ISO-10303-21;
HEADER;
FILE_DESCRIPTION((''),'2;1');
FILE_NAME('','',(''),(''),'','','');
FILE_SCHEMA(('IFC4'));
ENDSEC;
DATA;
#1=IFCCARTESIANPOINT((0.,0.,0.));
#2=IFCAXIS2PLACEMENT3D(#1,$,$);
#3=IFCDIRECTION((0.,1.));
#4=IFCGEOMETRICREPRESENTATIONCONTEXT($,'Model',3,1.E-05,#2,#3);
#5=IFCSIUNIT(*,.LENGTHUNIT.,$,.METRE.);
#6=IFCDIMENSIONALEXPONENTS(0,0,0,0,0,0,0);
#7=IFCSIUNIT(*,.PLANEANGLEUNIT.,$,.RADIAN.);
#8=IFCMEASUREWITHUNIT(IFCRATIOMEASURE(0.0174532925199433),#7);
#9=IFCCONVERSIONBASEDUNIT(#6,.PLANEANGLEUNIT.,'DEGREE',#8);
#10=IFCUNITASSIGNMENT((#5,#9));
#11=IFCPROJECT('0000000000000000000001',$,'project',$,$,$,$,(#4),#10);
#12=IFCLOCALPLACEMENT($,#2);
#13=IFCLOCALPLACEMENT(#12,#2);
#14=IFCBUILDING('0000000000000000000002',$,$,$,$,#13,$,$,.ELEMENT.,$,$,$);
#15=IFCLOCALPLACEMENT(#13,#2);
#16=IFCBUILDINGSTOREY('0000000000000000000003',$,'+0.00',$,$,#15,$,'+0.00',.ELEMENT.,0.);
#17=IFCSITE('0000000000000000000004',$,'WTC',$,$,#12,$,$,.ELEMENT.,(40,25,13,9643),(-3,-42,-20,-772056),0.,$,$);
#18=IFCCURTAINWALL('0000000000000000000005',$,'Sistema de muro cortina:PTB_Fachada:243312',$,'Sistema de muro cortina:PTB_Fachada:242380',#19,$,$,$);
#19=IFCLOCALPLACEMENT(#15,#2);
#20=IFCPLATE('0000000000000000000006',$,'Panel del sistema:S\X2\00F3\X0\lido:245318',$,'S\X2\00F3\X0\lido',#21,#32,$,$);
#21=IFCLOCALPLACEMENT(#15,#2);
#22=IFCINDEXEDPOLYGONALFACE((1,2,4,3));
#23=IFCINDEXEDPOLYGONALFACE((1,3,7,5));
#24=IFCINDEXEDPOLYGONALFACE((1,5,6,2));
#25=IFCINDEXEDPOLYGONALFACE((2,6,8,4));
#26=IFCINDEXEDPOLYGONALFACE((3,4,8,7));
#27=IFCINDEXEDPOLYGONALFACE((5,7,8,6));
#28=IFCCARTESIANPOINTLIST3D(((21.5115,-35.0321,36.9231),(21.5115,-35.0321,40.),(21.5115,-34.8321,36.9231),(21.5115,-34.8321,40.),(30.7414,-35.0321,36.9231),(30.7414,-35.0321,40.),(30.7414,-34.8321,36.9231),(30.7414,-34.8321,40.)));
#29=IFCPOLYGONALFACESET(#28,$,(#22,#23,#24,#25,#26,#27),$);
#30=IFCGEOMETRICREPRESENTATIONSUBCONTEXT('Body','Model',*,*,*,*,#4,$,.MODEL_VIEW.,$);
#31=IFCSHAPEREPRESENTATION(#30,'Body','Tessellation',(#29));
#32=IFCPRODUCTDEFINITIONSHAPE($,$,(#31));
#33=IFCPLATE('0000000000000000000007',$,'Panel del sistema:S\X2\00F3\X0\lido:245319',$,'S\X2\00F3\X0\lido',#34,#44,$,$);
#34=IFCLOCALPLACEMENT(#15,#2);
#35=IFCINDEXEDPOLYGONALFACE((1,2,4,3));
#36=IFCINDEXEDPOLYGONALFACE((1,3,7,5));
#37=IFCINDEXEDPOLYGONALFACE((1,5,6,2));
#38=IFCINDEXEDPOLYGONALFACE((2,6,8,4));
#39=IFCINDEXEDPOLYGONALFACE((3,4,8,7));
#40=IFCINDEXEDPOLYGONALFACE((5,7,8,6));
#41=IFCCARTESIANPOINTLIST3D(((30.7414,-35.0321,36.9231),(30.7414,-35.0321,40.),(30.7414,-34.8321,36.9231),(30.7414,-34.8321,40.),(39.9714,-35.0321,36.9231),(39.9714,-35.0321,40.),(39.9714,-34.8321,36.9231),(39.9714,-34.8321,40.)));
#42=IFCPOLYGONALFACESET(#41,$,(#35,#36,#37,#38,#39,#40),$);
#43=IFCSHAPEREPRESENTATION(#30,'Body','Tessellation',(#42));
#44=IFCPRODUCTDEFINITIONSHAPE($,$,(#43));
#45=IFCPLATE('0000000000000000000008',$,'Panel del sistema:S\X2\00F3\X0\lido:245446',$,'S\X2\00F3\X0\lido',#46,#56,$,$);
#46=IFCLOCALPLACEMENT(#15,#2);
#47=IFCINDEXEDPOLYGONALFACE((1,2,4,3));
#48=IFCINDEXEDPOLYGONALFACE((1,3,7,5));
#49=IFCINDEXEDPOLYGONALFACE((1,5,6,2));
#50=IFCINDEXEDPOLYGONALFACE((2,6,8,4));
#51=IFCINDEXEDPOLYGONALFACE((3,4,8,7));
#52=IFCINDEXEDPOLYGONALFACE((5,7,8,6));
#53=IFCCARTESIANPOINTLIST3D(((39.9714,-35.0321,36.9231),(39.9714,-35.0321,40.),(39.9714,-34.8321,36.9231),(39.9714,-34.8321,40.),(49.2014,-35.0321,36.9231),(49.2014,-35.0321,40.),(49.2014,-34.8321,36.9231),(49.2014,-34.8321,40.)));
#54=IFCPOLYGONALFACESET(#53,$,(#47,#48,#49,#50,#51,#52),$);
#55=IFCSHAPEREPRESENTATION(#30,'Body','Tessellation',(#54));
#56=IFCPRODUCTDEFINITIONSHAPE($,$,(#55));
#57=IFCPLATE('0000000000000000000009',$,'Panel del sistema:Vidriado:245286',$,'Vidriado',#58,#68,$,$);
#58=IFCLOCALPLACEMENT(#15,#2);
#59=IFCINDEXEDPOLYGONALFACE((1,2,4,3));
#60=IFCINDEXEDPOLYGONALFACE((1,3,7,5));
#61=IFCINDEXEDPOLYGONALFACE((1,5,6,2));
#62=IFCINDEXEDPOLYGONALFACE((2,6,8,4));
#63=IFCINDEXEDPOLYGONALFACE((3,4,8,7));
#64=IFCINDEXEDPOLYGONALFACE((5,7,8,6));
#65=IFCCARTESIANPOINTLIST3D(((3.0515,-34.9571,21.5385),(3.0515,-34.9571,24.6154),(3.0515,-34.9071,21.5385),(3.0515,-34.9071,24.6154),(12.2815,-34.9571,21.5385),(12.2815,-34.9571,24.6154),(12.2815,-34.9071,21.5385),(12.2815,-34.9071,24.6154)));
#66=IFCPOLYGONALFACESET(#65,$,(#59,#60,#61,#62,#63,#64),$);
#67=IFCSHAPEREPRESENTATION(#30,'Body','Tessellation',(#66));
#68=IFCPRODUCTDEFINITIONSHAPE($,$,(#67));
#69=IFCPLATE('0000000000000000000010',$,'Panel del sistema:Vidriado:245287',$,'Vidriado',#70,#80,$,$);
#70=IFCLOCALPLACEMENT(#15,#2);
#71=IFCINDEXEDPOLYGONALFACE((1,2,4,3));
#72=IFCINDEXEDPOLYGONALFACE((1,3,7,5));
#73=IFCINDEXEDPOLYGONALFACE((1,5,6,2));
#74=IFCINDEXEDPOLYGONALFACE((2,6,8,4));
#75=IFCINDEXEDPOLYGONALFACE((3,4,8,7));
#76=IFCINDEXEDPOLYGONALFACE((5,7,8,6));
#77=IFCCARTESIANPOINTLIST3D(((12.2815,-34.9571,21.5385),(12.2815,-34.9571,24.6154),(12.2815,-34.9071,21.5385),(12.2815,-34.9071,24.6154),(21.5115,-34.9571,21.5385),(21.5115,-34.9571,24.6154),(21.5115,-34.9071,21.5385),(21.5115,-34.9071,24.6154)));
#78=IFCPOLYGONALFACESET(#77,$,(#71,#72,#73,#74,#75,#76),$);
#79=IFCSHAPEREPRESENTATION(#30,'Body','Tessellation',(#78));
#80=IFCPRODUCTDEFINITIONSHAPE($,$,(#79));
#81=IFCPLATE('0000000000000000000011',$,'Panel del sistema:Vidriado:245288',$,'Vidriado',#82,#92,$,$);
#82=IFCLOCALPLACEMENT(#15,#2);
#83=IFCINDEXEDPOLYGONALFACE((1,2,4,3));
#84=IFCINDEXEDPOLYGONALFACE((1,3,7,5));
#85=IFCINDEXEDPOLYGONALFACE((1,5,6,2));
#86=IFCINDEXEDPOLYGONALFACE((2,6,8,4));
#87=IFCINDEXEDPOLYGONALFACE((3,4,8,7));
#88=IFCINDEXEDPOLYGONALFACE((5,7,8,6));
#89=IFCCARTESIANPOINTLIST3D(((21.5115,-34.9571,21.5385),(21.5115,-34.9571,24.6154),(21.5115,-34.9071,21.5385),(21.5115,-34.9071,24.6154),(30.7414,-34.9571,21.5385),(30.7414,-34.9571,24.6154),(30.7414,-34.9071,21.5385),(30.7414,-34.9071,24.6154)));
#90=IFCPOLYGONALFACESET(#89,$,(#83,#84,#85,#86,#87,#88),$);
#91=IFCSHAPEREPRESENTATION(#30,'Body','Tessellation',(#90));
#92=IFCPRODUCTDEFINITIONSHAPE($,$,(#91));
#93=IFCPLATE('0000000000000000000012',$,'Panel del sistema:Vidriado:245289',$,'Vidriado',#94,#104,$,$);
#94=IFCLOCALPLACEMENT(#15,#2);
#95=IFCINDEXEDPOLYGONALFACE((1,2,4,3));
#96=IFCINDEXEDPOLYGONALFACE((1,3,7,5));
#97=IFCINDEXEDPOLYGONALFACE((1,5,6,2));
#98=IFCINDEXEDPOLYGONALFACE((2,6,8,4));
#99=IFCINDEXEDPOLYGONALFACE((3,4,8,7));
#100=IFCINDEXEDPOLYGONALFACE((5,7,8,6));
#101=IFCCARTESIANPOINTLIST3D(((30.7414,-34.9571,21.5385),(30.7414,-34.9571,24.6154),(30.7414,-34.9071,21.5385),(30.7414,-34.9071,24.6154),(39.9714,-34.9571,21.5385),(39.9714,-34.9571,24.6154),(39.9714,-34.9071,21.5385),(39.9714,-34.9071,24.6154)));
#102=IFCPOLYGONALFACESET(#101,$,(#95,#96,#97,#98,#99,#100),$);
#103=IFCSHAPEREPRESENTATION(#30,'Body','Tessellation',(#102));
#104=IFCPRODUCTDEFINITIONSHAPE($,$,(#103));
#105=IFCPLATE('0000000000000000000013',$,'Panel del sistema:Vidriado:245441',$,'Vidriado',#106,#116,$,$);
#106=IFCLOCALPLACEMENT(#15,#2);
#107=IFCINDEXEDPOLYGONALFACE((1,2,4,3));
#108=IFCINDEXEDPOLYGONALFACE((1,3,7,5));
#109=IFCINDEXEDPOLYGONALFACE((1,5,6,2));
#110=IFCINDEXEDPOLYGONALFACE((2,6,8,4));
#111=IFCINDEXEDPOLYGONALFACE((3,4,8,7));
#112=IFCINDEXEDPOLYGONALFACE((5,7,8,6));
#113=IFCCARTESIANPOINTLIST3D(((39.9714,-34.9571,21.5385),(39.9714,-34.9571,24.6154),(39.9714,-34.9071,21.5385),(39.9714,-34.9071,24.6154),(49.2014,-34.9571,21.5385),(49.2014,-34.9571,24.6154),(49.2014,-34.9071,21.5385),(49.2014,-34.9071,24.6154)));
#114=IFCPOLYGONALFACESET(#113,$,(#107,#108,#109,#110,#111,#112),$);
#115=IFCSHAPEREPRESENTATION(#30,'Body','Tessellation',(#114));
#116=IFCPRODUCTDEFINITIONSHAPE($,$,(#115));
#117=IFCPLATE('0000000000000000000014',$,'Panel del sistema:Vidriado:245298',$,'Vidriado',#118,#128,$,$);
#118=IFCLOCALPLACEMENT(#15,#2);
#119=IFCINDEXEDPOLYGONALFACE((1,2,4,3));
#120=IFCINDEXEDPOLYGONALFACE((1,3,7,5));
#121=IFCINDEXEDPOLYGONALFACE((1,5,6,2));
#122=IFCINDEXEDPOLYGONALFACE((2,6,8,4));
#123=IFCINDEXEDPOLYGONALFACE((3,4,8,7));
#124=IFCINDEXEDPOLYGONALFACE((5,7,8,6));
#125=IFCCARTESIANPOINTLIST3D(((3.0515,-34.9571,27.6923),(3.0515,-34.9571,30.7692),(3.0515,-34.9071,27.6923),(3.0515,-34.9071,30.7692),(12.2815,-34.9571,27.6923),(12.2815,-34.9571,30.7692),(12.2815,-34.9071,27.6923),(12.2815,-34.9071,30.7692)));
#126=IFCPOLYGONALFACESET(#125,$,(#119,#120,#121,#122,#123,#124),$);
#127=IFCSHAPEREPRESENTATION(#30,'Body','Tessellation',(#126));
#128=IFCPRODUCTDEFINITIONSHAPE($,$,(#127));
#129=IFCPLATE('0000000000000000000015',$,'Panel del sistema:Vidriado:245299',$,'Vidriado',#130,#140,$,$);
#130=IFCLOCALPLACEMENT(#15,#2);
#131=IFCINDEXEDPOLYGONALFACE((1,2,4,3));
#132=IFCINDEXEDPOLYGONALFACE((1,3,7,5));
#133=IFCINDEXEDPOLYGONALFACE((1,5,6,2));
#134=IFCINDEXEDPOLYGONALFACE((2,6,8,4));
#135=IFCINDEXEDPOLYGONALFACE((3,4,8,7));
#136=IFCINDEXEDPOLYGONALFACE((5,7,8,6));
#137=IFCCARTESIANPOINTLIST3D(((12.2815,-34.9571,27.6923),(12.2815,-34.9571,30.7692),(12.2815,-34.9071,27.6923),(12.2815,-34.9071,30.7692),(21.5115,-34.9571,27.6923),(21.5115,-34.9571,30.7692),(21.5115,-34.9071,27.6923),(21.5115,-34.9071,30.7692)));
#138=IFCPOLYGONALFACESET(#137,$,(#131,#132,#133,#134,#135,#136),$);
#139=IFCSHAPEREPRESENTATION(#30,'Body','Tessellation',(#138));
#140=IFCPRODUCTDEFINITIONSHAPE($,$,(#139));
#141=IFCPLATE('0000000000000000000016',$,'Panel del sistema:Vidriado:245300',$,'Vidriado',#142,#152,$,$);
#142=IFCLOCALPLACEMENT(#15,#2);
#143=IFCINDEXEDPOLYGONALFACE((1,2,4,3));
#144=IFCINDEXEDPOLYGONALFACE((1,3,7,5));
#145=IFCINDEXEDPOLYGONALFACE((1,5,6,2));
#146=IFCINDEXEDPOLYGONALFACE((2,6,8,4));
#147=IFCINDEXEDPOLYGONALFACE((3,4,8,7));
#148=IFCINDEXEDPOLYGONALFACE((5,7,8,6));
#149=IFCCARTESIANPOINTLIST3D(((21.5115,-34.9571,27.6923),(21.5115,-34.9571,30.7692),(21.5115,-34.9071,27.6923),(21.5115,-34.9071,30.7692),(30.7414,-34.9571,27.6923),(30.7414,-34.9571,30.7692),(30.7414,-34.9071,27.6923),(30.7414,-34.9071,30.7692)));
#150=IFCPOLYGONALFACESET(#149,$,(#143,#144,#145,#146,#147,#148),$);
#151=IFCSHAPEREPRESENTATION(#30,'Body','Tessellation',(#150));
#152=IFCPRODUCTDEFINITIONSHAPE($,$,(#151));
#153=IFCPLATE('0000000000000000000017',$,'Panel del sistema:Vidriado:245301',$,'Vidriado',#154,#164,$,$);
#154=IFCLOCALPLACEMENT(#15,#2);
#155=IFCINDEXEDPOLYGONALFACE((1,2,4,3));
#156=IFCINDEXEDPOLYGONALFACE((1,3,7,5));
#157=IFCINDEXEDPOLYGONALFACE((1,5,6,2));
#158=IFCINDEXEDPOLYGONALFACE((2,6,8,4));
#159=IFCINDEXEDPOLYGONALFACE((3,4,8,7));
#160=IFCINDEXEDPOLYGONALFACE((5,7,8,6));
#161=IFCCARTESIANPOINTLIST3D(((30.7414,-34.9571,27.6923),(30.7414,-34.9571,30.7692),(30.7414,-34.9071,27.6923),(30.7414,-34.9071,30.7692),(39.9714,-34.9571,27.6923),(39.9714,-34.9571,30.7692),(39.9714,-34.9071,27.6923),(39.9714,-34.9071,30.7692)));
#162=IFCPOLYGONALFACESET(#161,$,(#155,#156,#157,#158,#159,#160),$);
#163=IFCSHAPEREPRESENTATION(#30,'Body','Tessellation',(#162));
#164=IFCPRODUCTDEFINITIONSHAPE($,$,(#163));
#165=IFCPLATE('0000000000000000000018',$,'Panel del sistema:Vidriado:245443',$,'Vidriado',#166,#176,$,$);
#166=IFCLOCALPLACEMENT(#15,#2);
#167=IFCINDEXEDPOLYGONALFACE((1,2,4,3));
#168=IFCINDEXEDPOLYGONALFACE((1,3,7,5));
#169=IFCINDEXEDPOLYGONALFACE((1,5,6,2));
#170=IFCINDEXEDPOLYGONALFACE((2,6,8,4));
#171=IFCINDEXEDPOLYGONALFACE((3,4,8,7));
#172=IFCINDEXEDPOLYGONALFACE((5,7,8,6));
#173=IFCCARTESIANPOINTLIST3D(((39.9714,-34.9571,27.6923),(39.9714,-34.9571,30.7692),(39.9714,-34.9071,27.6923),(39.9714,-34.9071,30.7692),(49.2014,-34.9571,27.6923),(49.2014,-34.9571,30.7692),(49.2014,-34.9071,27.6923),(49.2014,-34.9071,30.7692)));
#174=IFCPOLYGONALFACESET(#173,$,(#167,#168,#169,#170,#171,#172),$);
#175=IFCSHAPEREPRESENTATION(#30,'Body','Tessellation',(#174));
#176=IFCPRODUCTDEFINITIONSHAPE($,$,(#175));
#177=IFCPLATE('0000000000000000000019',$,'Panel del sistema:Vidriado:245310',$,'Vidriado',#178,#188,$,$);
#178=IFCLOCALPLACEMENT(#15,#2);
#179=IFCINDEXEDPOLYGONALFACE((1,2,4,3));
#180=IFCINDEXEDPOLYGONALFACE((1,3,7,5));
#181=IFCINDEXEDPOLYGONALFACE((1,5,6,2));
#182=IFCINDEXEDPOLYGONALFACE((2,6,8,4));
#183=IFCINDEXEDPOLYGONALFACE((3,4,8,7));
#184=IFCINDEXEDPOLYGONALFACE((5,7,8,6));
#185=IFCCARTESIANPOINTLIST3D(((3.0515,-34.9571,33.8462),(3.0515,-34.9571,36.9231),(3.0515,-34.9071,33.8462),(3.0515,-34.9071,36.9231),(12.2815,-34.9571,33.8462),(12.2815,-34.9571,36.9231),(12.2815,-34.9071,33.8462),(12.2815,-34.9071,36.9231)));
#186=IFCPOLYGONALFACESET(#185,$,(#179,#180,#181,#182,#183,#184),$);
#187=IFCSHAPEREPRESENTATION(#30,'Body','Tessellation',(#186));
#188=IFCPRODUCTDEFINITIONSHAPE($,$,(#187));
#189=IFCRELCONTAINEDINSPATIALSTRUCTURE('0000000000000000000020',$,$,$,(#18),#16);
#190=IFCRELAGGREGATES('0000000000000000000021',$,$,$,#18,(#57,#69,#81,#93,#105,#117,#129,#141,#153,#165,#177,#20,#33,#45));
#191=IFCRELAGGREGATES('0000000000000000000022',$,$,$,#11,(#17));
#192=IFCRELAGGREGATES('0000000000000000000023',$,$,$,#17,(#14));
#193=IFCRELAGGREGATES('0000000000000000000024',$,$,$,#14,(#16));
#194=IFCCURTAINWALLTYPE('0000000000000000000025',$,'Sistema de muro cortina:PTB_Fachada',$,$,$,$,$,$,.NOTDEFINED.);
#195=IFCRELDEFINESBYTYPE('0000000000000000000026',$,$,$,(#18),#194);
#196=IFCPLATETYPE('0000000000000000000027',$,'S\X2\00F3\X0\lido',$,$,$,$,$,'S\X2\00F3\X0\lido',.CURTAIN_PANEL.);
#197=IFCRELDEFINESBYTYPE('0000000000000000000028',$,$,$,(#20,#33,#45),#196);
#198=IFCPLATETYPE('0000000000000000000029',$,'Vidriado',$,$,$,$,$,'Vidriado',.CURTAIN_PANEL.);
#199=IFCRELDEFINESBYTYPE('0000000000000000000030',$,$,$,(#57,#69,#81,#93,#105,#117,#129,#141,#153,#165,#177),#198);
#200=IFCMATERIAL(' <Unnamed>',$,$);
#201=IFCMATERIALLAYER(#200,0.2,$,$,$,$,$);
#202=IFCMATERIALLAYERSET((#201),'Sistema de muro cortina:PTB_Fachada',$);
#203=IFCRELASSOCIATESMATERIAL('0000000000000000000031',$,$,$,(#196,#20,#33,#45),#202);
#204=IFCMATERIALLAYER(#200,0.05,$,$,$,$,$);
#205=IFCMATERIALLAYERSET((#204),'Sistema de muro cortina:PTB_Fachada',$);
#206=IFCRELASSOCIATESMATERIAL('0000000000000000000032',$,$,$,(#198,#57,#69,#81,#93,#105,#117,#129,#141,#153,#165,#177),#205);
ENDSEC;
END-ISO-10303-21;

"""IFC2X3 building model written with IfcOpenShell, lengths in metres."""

from ifc_helpers import new_model, entity, si_unit, converted_unit, direction, frame, frame_2d, origin, origin_2d_with_axis, place, context, subcontext, project, spatial, rectangle, extrude, source, transform, mapped, material, layer, layer_set, layer_usage, type_object, type_shapes, element, aggregate, save


model = new_model("IFC2X3")

# Units and contexts
model_context = context("Model", 3, precision=1e-05, world=origin(), true_north=direction((0.0, 1.0)))
body_context = subcontext(model_context, "Body", "Model", "MODEL_VIEW")
ifc_project = project(units=[si_unit("LENGTHUNIT", "METRE"), converted_unit("PLANEANGLEUNIT", "DEGREE", entity("IfcRatioMeasure", 0.0174532925199433), si_unit("PLANEANGLEUNIT", "RADIAN"), dimensions=[0, 0, 0, 0, 0, 0, 0])], contexts=[model_context])

# Site, building, storey
site_placement = place(None, origin())
site = spatial("IfcSite", under=ifc_project, at=site_placement, Name="WTC", CompositionType="ELEMENT", RefLatitude=(40, 25, 13, 9643), RefLongitude=(-3, -42, -20, -772056), RefElevation=0.0)
building_placement = place(site_placement, origin())
building = spatial("IfcBuilding", under=site, at=building_placement, CompositionType="ELEMENT")
storey_placement = place(building_placement, origin())
storey = spatial("IfcBuildingStorey", under=building, at=storey_placement, Name="+0.00", LongName="+0.00", CompositionType="ELEMENT", Elevation=0.0)

# Curtain wall, plates
curtain_wall_type = type_object("IfcCurtainWallType", Name="Sistema de muro cortina:PTB_Fachada", PredefinedType="NOTDEFINED")
curtain_wall_placement = place(storey_placement, origin())
curtain_wall = element("IfcCurtainWall", 1, at=curtain_wall_placement, inside=storey, type_object=curtain_wall_type, Name="Sistema de muro cortina:PTB_Fachada:243312", ObjectType="Sistema de muro cortina:PTB_Fachada:242380")
ifc_material_1 = material(Name=" <Unnamed>")
ifc_layer_1 = layer(ifc_material_1, 0.2)
ifc_layer_set_1 = layer_set([ifc_layer_1], Name="Sistema de muro cortina:PTB_Fachada")
plate_type_1 = type_object("IfcPlateType", Name="Sólido", ElementType="Sólido", PredefinedType="CURTAIN_PANEL", material=ifc_layer_set_1)
shared_shape_1 = source(origin(), body_context, "Body", "SweptSolid", [
    extrude(rectangle(XDim=0.2, YDim=9.23, at=frame_2d((0.0, 0.0), x_axis=(1.0, 0.0))), frame((0.0, 0.0, 0.0), z_axis=(0.0, 0.0, 1.0), x_axis=(0.0, 1.0, 0.0)), (0.0, 0.0, 1.0), 3.0769),
])
type_shapes(plate_type_1, [shared_shape_1])
ifc_layer_usage_1 = layer_usage(ifc_layer_set_1, "AXIS3", "POSITIVE", 0.0)
plate_1_placement = place(curtain_wall_placement, frame((26.1265, -34.9321, 36.9231)))
plate_1 = element("IfcPlate", 2, at=plate_1_placement, type_object=plate_type_1, material=ifc_layer_usage_1, Name="Panel del sistema:Sólido:245318", ObjectType="Sólido", context=body_context, shape_type="MappedRepresentation", body=[
    mapped(shared_shape_1, transform((0.0, 0.0, 0.0), scale=1.0)),
])
ifc_layer_usage_2 = layer_usage(ifc_layer_set_1, "AXIS3", "POSITIVE", 0.0)
plate_2_placement = place(curtain_wall_placement, frame((35.3564, -34.9321, 36.9231)))
plate_2 = element("IfcPlate", 3, at=plate_2_placement, type_object=plate_type_1, material=ifc_layer_usage_2, Name="Panel del sistema:Sólido:245319", ObjectType="Sólido", context=body_context, shape_type="MappedRepresentation", body=[
    mapped(shared_shape_1, transform((0.0, 0.0, 0.0), scale=1.0)),
])
ifc_layer_usage_3 = layer_usage(ifc_layer_set_1, "AXIS3", "POSITIVE", 0.0)
plate_3_placement = place(curtain_wall_placement, frame((44.5864, -34.9321, 36.9231)))
plate_3 = element("IfcPlate", 4, at=plate_3_placement, type_object=plate_type_1, material=ifc_layer_usage_3, Name="Panel del sistema:Sólido:245446", ObjectType="Sólido", context=body_context, shape_type="MappedRepresentation", body=[
    mapped(shared_shape_1, transform((0.0, 0.0, 0.0), scale=1.0)),
])
ifc_layer_2 = layer(ifc_material_1, 0.05)
ifc_layer_set_2 = layer_set([ifc_layer_2], Name="Sistema de muro cortina:PTB_Fachada")
ifc_layer_usage_4 = layer_usage(ifc_layer_set_2, "AXIS3", "POSITIVE", 0.0)
plate_type_2 = type_object("IfcPlateType", Name="Vidriado", ElementType="Vidriado", PredefinedType="CURTAIN_PANEL", material=ifc_layer_set_2)
shared_shape_2 = source(origin(), body_context, "Body", "SweptSolid", [
    extrude(rectangle(XDim=0.05, YDim=9.23, at=origin_2d_with_axis()), frame((0.0, 0.0, 0.0), z_axis=(0.0, 0.0, 1.0), x_axis=(0.0, 1.0, 0.0)), (0.0, 0.0, 1.0), 3.0769),
])
type_shapes(plate_type_2, [shared_shape_2])
plate_4_placement = place(curtain_wall_placement, frame((7.6665, -34.9321, 21.5385)))
plate_4 = element("IfcPlate", 5, at=plate_4_placement, type_object=plate_type_2, material=ifc_layer_usage_4, Name="Panel del sistema:Vidriado:245286", ObjectType="Vidriado", context=body_context, shape_type="MappedRepresentation", body=[
    mapped(shared_shape_2, transform((0.0, 0.0, 0.0), scale=1.0)),
])
ifc_layer_usage_5 = layer_usage(ifc_layer_set_2, "AXIS3", "POSITIVE", 0.0)
plate_5_placement = place(curtain_wall_placement, frame((16.8965, -34.9321, 21.5385)))
plate_5 = element("IfcPlate", 6, at=plate_5_placement, type_object=plate_type_2, material=ifc_layer_usage_5, Name="Panel del sistema:Vidriado:245287", ObjectType="Vidriado", context=body_context, shape_type="MappedRepresentation", body=[
    mapped(shared_shape_2, transform((0.0, 0.0, 0.0), scale=1.0)),
])
ifc_layer_usage_6 = layer_usage(ifc_layer_set_2, "AXIS3", "POSITIVE", 0.0)
plate_6_placement = place(curtain_wall_placement, frame((26.1265, -34.9321, 21.5385)))
plate_6 = element("IfcPlate", 7, at=plate_6_placement, type_object=plate_type_2, material=ifc_layer_usage_6, Name="Panel del sistema:Vidriado:245288", ObjectType="Vidriado", context=body_context, shape_type="MappedRepresentation", body=[
    mapped(shared_shape_2, transform((0.0, 0.0, 0.0), scale=1.0)),
])
ifc_layer_usage_7 = layer_usage(ifc_layer_set_2, "AXIS3", "POSITIVE", 0.0)
plate_7_placement = place(curtain_wall_placement, frame((35.3564, -34.9321, 21.5385)))
plate_7 = element("IfcPlate", 8, at=plate_7_placement, type_object=plate_type_2, material=ifc_layer_usage_7, Name="Panel del sistema:Vidriado:245289", ObjectType="Vidriado", context=body_context, shape_type="MappedRepresentation", body=[
    mapped(shared_shape_2, transform((0.0, 0.0, 0.0), scale=1.0)),
])
ifc_layer_usage_8 = layer_usage(ifc_layer_set_2, "AXIS3", "POSITIVE", 0.0)
plate_8_placement = place(curtain_wall_placement, frame((44.5864, -34.9321, 21.5385)))
plate_8 = element("IfcPlate", 9, at=plate_8_placement, type_object=plate_type_2, material=ifc_layer_usage_8, Name="Panel del sistema:Vidriado:245441", ObjectType="Vidriado", context=body_context, shape_type="MappedRepresentation", body=[
    mapped(shared_shape_2, transform((0.0, 0.0, 0.0), scale=1.0)),
])
ifc_layer_usage_9 = layer_usage(ifc_layer_set_2, "AXIS3", "POSITIVE", 0.0)
plate_9_placement = place(curtain_wall_placement, frame((7.6665, -34.9321, 27.6923)))
plate_9 = element("IfcPlate", 10, at=plate_9_placement, type_object=plate_type_2, material=ifc_layer_usage_9, Name="Panel del sistema:Vidriado:245298", ObjectType="Vidriado", context=body_context, shape_type="MappedRepresentation", body=[
    mapped(shared_shape_2, transform((0.0, 0.0, 0.0), scale=1.0)),
])
ifc_layer_usage_10 = layer_usage(ifc_layer_set_2, "AXIS3", "POSITIVE", 0.0)
plate_10_placement = place(curtain_wall_placement, frame((16.8965, -34.9321, 27.6923)))
plate_10 = element("IfcPlate", 11, at=plate_10_placement, type_object=plate_type_2, material=ifc_layer_usage_10, Name="Panel del sistema:Vidriado:245299", ObjectType="Vidriado", context=body_context, shape_type="MappedRepresentation", body=[
    mapped(shared_shape_2, transform((0.0, 0.0, 0.0), scale=1.0)),
])
ifc_layer_usage_11 = layer_usage(ifc_layer_set_2, "AXIS3", "POSITIVE", 0.0)
plate_11_placement = place(curtain_wall_placement, frame((26.1265, -34.9321, 27.6923)))
plate_11 = element("IfcPlate", 12, at=plate_11_placement, type_object=plate_type_2, material=ifc_layer_usage_11, Name="Panel del sistema:Vidriado:245300", ObjectType="Vidriado", context=body_context, shape_type="MappedRepresentation", body=[
    mapped(shared_shape_2, transform((0.0, 0.0, 0.0), scale=1.0)),
])
ifc_layer_usage_12 = layer_usage(ifc_layer_set_2, "AXIS3", "POSITIVE", 0.0)
plate_12_placement = place(curtain_wall_placement, frame((35.3564, -34.9321, 27.6923)))
plate_12 = element("IfcPlate", 13, at=plate_12_placement, type_object=plate_type_2, material=ifc_layer_usage_12, Name="Panel del sistema:Vidriado:245301", ObjectType="Vidriado", context=body_context, shape_type="MappedRepresentation", body=[
    mapped(shared_shape_2, transform((0.0, 0.0, 0.0), scale=1.0)),
])
ifc_layer_usage_13 = layer_usage(ifc_layer_set_2, "AXIS3", "POSITIVE", 0.0)
plate_13_placement = place(curtain_wall_placement, frame((44.5864, -34.9321, 27.6923)))
plate_13 = element("IfcPlate", 14, at=plate_13_placement, type_object=plate_type_2, material=ifc_layer_usage_13, Name="Panel del sistema:Vidriado:245443", ObjectType="Vidriado", context=body_context, shape_type="MappedRepresentation", body=[
    mapped(shared_shape_2, transform((0.0, 0.0, 0.0), scale=1.0)),
])
ifc_layer_usage_14 = layer_usage(ifc_layer_set_2, "AXIS3", "POSITIVE", 0.0)
plate_14_placement = place(curtain_wall_placement, frame((7.6665, -34.9321, 33.8462)))
plate_14 = element("IfcPlate", 15, at=plate_14_placement, type_object=plate_type_2, material=ifc_layer_usage_14, Name="Panel del sistema:Vidriado:245310", ObjectType="Vidriado", context=body_context, shape_type="MappedRepresentation", body=[
    mapped(shared_shape_2, transform((0.0, 0.0, 0.0), scale=1.0)),
])
aggregate(curtain_wall, [plate_4, plate_5, plate_6, plate_7, plate_8, plate_9, plate_10, plate_11, plate_12, plate_13, plate_14, plate_1, plate_2, plate_3])

save(model, "model.ifc")
